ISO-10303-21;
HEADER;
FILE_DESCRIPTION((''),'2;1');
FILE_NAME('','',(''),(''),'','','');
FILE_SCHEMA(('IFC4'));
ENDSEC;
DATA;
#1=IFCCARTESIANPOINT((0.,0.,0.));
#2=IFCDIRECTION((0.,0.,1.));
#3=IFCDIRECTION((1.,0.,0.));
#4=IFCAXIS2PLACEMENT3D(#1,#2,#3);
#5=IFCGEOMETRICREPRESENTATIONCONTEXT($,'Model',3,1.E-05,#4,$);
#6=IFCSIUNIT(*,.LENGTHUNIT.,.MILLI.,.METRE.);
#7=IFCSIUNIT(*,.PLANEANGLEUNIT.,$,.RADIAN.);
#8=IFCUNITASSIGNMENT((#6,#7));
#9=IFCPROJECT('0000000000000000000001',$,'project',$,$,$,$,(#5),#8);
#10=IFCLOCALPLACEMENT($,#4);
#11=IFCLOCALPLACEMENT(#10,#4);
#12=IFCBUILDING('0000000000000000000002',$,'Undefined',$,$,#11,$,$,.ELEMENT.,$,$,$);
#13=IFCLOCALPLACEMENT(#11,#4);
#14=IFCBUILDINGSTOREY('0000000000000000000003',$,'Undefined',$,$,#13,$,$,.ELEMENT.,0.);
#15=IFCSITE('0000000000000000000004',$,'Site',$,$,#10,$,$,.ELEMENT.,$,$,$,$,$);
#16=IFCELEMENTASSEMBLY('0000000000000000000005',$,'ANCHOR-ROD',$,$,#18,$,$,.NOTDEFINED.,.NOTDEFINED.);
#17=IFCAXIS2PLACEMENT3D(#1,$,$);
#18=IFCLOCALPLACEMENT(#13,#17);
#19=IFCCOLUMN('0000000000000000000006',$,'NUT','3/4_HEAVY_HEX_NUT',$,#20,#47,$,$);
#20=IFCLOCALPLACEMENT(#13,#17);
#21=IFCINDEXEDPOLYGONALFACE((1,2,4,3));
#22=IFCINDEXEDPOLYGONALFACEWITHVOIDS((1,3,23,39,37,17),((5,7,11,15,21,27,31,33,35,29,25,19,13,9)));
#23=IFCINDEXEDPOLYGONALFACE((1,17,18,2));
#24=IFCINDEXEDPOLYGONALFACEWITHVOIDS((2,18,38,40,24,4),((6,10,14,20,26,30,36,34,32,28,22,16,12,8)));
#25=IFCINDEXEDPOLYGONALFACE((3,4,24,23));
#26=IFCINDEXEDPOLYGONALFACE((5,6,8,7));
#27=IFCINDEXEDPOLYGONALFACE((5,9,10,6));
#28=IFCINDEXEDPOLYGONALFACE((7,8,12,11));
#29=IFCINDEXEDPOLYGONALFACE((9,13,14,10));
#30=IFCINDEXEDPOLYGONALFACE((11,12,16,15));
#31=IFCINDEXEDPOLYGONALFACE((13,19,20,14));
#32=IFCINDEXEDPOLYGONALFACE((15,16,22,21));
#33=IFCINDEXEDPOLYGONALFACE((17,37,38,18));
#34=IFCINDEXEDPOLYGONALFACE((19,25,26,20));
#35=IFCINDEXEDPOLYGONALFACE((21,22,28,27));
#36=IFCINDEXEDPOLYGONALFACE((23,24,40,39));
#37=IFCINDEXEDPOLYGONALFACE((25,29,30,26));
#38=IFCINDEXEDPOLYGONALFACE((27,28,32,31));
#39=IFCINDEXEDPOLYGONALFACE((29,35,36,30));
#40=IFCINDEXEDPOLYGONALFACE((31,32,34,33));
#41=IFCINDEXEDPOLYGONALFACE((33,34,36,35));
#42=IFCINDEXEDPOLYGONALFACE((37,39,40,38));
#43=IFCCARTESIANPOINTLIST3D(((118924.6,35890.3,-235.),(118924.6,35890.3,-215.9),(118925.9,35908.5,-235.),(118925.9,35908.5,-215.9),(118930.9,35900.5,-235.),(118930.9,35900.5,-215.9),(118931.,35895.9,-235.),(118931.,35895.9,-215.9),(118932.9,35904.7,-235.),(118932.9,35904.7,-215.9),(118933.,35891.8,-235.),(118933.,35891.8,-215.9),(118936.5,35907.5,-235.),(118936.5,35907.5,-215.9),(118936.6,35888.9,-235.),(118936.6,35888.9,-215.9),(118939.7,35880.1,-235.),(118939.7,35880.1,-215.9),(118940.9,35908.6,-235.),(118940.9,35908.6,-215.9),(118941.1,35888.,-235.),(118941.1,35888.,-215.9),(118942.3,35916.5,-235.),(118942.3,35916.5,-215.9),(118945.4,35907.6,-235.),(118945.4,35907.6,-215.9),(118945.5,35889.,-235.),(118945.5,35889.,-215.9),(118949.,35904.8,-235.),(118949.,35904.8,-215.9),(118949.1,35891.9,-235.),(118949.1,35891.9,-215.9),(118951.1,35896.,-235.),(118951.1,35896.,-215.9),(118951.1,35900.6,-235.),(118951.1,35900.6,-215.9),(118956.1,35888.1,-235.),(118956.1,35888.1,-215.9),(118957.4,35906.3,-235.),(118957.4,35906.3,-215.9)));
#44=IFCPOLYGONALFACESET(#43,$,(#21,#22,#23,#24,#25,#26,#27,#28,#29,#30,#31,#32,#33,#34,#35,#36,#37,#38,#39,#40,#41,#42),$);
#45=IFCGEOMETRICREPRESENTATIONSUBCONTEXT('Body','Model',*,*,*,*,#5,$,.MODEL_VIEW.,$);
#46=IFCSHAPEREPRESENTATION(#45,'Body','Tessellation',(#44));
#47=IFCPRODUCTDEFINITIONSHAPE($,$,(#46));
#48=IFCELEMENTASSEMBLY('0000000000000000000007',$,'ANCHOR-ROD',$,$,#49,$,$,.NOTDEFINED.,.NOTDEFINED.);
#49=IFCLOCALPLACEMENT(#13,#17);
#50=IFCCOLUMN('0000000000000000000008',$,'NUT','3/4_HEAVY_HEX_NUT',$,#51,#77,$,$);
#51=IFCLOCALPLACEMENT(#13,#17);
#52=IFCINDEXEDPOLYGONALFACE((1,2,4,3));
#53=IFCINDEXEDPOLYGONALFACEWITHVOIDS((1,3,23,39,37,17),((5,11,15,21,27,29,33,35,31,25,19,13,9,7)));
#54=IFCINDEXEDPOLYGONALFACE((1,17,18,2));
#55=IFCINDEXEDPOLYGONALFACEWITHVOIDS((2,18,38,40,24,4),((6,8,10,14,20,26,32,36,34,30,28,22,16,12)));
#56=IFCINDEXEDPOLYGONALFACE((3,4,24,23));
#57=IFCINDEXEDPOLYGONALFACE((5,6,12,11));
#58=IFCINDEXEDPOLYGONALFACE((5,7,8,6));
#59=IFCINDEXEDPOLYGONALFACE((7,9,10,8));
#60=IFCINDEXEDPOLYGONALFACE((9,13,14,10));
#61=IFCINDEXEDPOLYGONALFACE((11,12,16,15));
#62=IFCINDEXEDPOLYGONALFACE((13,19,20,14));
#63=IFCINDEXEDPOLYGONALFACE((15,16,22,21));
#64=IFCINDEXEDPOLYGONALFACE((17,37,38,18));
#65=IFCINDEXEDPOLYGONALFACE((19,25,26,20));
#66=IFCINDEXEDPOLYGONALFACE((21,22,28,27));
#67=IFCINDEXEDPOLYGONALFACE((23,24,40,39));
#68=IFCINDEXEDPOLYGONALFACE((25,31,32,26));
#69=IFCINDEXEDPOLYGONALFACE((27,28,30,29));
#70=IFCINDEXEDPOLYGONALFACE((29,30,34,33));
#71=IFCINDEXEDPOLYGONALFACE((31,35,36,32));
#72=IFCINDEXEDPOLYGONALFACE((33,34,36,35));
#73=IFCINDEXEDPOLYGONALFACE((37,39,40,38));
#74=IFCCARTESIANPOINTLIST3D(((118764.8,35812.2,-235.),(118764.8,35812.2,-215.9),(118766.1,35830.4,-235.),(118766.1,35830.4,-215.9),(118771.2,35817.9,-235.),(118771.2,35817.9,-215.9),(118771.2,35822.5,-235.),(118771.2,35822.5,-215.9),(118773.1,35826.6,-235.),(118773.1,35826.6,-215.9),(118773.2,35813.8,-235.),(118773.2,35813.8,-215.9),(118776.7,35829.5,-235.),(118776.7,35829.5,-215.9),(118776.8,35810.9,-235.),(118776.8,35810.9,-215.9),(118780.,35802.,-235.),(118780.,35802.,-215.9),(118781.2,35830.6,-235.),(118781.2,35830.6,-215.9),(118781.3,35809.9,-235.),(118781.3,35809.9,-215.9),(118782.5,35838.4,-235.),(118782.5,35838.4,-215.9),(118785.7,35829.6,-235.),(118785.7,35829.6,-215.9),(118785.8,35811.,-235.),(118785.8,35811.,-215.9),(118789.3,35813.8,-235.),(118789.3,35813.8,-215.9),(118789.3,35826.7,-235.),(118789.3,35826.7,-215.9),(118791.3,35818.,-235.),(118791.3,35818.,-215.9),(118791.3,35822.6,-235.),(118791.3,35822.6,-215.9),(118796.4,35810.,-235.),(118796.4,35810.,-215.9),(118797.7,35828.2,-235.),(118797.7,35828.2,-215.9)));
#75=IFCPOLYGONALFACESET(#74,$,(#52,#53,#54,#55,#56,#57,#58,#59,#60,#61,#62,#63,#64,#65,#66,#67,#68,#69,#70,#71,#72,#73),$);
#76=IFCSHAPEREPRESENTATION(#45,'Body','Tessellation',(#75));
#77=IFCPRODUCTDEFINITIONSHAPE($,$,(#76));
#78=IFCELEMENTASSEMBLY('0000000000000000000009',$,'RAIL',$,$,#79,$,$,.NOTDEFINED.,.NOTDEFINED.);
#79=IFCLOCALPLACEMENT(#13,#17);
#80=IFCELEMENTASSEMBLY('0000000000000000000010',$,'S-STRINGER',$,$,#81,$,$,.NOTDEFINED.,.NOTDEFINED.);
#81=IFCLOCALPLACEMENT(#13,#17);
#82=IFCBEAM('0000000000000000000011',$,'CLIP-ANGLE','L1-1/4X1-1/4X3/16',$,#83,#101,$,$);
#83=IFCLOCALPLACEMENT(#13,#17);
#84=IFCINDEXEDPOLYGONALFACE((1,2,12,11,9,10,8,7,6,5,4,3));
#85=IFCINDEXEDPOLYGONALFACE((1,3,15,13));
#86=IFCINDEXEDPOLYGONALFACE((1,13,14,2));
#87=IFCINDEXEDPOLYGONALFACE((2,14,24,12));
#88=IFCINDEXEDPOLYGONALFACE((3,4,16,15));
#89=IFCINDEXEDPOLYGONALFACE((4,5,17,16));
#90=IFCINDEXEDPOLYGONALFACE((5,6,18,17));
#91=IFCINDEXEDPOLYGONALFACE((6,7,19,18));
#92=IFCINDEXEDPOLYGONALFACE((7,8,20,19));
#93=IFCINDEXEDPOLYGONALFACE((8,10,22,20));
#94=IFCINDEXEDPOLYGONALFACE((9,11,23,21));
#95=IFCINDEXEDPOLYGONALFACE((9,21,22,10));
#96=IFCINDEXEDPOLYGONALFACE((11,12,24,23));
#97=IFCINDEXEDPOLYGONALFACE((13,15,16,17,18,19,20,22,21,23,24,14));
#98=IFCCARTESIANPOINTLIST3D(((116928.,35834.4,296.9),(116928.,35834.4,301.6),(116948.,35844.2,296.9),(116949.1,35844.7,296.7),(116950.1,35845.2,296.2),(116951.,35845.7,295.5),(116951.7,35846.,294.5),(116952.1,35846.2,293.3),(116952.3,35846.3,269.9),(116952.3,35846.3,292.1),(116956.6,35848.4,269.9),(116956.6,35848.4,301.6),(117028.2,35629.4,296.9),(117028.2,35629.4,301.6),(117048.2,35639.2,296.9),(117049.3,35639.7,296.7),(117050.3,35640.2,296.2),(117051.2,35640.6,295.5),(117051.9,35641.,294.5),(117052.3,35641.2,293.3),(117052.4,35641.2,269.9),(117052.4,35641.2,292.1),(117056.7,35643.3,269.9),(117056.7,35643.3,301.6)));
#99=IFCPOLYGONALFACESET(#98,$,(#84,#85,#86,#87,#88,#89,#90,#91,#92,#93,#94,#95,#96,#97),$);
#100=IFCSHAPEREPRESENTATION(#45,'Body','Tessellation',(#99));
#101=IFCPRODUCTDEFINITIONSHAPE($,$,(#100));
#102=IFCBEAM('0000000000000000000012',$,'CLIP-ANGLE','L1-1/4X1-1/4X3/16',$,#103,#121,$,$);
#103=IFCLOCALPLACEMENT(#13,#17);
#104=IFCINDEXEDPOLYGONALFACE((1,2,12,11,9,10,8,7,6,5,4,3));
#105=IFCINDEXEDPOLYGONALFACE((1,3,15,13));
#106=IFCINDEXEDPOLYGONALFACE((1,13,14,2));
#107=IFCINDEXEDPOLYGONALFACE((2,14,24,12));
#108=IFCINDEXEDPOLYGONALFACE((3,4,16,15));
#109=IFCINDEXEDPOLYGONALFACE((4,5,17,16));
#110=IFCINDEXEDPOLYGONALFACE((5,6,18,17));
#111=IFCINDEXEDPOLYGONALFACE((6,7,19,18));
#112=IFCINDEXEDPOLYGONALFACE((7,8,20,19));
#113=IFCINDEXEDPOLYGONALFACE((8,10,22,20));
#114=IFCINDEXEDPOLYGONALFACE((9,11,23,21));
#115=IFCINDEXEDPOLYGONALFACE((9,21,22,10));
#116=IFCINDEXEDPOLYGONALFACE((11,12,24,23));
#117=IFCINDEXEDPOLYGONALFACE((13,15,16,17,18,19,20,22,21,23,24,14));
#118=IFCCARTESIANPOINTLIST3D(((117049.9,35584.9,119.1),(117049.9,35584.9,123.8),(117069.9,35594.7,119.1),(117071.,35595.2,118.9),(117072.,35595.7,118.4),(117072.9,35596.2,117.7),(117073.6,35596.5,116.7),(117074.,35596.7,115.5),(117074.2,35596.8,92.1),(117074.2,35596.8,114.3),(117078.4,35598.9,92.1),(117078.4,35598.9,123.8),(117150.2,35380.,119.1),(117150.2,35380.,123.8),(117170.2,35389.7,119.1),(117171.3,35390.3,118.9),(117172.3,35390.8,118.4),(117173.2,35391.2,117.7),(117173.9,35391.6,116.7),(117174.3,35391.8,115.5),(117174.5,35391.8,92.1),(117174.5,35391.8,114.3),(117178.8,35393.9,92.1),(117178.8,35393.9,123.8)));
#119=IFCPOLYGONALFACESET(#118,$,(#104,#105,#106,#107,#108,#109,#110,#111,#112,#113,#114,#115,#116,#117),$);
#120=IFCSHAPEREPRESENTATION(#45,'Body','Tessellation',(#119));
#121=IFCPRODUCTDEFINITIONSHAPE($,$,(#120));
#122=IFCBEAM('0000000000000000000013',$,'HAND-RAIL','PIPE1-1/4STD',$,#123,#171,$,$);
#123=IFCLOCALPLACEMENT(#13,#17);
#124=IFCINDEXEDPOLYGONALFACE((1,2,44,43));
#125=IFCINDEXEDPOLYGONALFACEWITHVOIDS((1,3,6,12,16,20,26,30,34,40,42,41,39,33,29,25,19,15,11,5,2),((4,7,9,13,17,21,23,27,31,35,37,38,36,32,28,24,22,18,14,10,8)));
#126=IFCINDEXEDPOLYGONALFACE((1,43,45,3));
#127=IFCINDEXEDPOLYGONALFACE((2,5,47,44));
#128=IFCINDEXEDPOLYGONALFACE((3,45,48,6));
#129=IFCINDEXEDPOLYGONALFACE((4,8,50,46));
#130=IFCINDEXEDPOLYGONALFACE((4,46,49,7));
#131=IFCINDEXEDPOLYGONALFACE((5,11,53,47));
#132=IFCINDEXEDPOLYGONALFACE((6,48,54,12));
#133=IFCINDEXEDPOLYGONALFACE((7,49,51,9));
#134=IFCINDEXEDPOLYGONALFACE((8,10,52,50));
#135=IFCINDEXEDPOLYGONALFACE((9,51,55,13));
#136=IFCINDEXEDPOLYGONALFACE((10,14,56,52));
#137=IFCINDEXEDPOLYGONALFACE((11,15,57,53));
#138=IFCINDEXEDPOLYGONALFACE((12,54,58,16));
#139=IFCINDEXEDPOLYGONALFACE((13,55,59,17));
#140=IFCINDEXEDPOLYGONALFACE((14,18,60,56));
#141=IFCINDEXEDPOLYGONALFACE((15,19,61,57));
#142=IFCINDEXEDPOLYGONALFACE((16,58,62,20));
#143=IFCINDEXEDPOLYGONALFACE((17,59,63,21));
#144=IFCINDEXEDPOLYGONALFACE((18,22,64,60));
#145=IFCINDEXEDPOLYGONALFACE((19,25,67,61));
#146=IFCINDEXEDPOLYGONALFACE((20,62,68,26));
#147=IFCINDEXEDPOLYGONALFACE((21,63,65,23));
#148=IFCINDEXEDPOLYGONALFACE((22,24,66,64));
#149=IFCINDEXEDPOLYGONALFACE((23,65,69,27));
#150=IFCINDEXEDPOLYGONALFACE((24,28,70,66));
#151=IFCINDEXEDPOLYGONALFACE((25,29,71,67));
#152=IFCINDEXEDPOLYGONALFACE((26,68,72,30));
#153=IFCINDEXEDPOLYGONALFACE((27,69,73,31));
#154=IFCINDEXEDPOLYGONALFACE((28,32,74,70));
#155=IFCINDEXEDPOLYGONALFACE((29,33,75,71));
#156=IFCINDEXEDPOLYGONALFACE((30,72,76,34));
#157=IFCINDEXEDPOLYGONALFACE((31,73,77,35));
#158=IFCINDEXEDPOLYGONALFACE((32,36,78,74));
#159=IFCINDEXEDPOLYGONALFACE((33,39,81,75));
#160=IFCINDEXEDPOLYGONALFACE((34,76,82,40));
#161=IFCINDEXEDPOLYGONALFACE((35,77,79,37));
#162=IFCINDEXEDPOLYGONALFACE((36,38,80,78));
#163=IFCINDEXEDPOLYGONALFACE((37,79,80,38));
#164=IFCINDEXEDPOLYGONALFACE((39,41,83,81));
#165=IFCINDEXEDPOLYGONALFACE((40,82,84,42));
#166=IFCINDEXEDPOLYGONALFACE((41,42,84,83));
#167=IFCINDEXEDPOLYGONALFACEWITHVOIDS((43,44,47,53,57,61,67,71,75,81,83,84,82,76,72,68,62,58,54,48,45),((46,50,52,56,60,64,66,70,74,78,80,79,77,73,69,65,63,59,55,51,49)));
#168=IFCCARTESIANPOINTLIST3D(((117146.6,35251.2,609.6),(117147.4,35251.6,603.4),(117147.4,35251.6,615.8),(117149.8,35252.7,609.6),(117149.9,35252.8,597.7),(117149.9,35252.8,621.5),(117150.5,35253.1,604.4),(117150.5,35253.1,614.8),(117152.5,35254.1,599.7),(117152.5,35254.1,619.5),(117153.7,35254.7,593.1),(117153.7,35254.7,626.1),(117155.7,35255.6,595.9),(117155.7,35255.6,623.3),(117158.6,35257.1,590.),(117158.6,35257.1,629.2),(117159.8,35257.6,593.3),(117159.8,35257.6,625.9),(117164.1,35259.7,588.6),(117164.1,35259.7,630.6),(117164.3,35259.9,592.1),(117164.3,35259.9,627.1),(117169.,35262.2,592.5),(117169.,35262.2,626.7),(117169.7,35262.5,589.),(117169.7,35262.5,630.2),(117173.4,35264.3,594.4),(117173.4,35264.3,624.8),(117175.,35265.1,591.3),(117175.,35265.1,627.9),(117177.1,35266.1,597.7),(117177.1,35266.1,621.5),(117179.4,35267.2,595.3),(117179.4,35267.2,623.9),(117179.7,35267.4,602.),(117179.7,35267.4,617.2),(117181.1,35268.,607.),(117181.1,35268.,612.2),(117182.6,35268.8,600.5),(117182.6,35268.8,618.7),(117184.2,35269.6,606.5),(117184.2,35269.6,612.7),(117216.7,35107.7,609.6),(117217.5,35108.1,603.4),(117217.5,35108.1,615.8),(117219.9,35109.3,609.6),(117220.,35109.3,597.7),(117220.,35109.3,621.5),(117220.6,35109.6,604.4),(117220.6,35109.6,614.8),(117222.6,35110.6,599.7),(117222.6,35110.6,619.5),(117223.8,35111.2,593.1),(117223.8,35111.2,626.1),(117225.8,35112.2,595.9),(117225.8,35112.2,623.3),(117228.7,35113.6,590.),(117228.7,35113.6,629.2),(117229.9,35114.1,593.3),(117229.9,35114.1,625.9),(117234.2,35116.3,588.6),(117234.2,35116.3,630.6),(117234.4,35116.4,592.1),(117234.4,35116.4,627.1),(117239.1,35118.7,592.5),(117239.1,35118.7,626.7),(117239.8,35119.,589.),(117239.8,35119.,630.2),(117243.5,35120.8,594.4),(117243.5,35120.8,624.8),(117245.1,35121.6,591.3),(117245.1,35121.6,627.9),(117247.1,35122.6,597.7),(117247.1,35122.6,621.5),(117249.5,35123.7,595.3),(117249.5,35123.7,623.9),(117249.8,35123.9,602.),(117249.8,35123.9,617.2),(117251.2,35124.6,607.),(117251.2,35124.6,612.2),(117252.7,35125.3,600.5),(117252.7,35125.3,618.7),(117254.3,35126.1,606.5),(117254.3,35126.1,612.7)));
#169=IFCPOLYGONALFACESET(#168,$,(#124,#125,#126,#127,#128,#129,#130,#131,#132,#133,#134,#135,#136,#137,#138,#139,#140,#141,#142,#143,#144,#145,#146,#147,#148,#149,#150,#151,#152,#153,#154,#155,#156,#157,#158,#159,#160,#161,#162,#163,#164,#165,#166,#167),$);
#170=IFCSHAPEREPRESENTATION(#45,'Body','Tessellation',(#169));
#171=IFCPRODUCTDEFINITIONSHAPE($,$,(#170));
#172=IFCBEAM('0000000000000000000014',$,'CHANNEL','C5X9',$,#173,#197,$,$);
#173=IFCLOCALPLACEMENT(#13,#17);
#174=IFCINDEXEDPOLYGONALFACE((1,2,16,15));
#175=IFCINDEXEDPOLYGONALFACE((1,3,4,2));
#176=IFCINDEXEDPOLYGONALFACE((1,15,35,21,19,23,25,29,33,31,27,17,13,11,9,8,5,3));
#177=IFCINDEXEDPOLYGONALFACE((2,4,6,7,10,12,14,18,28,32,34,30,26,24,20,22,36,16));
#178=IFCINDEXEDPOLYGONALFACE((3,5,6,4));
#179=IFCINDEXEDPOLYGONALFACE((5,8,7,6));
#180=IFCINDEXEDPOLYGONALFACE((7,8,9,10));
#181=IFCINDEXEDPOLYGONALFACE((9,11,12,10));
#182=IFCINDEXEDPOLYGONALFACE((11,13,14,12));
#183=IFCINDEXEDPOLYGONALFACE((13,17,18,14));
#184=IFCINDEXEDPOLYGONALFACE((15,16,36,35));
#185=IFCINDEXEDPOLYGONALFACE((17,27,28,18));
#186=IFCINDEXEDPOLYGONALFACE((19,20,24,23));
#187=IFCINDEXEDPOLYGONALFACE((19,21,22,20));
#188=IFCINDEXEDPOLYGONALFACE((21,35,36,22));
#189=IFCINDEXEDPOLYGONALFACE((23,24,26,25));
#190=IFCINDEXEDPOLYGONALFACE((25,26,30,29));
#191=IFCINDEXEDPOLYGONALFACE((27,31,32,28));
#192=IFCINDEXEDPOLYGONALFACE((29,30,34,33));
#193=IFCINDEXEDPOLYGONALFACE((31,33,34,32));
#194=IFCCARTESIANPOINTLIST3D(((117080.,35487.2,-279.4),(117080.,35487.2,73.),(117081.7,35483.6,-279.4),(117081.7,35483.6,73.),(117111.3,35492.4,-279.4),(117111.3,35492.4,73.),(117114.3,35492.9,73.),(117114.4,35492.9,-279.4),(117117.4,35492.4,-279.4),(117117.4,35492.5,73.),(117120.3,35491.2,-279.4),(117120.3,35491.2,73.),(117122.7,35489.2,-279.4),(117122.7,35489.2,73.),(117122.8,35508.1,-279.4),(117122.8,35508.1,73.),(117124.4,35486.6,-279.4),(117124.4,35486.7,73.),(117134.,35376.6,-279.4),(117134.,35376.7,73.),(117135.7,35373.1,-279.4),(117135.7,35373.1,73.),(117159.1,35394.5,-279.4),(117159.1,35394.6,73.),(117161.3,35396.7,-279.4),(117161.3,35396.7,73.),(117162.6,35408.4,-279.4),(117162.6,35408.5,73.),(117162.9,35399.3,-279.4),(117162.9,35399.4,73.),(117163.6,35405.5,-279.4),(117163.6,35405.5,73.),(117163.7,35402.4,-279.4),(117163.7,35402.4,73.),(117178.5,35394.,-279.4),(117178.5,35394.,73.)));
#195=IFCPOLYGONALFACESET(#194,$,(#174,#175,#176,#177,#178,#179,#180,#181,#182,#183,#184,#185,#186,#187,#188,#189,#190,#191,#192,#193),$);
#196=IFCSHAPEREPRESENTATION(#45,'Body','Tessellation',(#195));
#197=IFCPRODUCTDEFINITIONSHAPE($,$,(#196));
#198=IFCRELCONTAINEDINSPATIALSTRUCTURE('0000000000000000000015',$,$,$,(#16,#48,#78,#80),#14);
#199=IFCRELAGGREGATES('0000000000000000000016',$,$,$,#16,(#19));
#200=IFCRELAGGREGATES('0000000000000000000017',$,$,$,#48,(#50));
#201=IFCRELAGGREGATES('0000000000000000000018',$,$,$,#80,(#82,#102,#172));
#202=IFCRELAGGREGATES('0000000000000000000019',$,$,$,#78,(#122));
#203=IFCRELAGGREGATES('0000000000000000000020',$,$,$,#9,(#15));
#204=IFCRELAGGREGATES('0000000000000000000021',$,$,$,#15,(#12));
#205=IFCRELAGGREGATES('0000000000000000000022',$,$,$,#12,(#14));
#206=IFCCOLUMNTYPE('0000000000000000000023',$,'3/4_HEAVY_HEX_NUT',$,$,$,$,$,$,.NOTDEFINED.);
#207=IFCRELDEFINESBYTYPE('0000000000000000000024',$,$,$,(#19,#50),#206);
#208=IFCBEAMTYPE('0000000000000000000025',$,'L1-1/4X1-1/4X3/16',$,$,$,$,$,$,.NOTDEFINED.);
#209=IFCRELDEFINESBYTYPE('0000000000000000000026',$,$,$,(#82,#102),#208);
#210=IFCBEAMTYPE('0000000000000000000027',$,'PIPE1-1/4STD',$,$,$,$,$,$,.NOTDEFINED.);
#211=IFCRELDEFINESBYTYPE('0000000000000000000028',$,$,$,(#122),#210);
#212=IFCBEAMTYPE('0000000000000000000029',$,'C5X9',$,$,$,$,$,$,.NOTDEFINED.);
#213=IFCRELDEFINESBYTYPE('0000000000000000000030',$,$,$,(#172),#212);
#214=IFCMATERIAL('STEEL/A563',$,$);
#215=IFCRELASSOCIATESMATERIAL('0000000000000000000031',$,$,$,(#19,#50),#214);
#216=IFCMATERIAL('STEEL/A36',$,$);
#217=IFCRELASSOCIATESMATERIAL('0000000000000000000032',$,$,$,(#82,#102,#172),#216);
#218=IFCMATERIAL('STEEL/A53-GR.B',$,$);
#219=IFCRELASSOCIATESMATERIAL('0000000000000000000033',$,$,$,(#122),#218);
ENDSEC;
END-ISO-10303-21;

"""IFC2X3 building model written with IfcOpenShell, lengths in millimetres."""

from ifc_helpers import new_model, si_unit, frame, origin_with_axes, origin_2d_with_axis, place, context, subcontext, project, spatial, polyline, hollow_circle, l_section, u_section, outline, extrude, material, type_object, element, aggregate, save


model = new_model("IFC2X3")

# Units and contexts
model_context = context("Model", 3, precision=1e-05, world=origin_with_axes())
body_context = subcontext(model_context, "Body", "Model", "MODEL_VIEW")
ifc_project = project(units=[si_unit("LENGTHUNIT", "METRE", prefix="MILLI"), si_unit("PLANEANGLEUNIT", "RADIAN")], contexts=[model_context])

# Site, building, storey
site_placement = place(None, origin_with_axes())
site = spatial("IfcSite", under=ifc_project, at=site_placement, Name="Site", CompositionType="ELEMENT")
building_placement = place(site_placement, origin_with_axes())
building = spatial("IfcBuilding", under=site, at=building_placement, Name="Undefined", CompositionType="ELEMENT")
storey_placement = place(building_placement, origin_with_axes())
storey = spatial("IfcBuildingStorey", under=building, at=storey_placement, Name="Undefined", CompositionType="ELEMENT", Elevation=0.0)

# Element assemblies, columns
ifc_material_1 = material(Name="STEEL/A563")
column_type_1 = type_object("IfcColumnType", Name="3/4_HEAVY_HEX_NUT", PredefinedType="NOTDEFINED")
assembly_1_placement = place(storey_placement, origin_with_axes())
assembly_1 = element("IfcElementAssembly", 1, at=assembly_1_placement, inside=storey, Name="ANCHOR-ROD", AssemblyPlace="NOTDEFINED", PredefinedType="NOTDEFINED")
column_1_placement = place(assembly_1_placement, frame((118941.0, 35898.3, -215.9), z_axis=(0.0, 0.0, -1.0), x_axis=(-0.438909, 0.898531, 0.0)))
column_1 = element("IfcColumn", 2, at=column_1_placement, type_object=column_type_1, material=ifc_material_1, Name="NUT", Description="3/4_HEAVY_HEX_NUT", context=body_context, shape_type="SweptSolid", body=[
    extrude(outline(polyline([(-9.1, 15.8), (9.1, 15.8), (18.3, 0.0), (9.1, -15.8), (-9.1, -15.8), (-18.3, 0.0), (-9.1, 15.8)]), holes=[polyline([(8.1, -6.4), (10.1, -2.3), (10.1, 2.3), (8.1, 6.4), (4.5, 9.3), (0.0, 10.3), (-4.5, 9.3), (-8.1, 6.4), (-10.1, 2.3), (-10.1, -2.3), (-8.1, -6.4), (-4.5, -9.3), (0.0, -10.3), (4.5, -9.3), (8.1, -6.4)])]), frame((0.0, 0.0, 19.1), z_axis=(0.0, 0.0, -1.0), x_axis=(0.0, 1.0, 0.0)), (0.0, 0.0, 1.0), 19.1),
])
aggregate(assembly_1, [column_1])
assembly_2_placement = place(storey_placement, origin_with_axes())
assembly_2 = element("IfcElementAssembly", 3, at=assembly_2_placement, inside=storey, Name="ANCHOR-ROD", AssemblyPlace="NOTDEFINED", PredefinedType="NOTDEFINED")
column_2_placement = place(assembly_2_placement, frame((118781.2, 35820.2, -215.9), z_axis=(0.0, 0.0, -1.0), x_axis=(0.438909, -0.898531, 0.0)))
column_2 = element("IfcColumn", 4, at=column_2_placement, type_object=column_type_1, material=ifc_material_1, Name="NUT", Description="3/4_HEAVY_HEX_NUT", context=body_context, shape_type="SweptSolid", body=[
    extrude(outline(polyline([(-9.1, 15.8), (9.1, 15.8), (18.3, 0.0), (9.1, -15.8), (-9.1, -15.8), (-18.3, 0.0), (-9.1, 15.8)]), holes=[polyline([(8.1, -6.4), (10.1, -2.3), (10.1, 2.3), (8.1, 6.4), (4.5, 9.3), (0.0, 10.3), (-4.5, 9.3), (-8.1, 6.4), (-10.1, 2.3), (-10.1, -2.3), (-8.1, -6.4), (-4.5, -9.3), (0.0, -10.3), (4.5, -9.3), (8.1, -6.4)])]), frame((0.0, 0.0, 19.1), z_axis=(0.0, 0.0, -1.0), x_axis=(0.0, 1.0, 0.0)), (0.0, 0.0, 1.0), 19.1),
])
aggregate(assembly_2, [column_2])
assembly_3_placement = place(storey_placement, origin_with_axes())
assembly_3 = element("IfcElementAssembly", 5, at=assembly_3_placement, inside=storey, Name="RAIL", AssemblyPlace="NOTDEFINED", PredefinedType="NOTDEFINED")

# Element assembly, beams
assembly_4_placement = place(storey_placement, origin_with_axes())
assembly_4 = element("IfcElementAssembly", 6, at=assembly_4_placement, inside=storey, Name="S-STRINGER", AssemblyPlace="NOTDEFINED", PredefinedType="NOTDEFINED")
ifc_material_2 = material(Name="STEEL/A36")
beam_type_1 = type_object("IfcBeamType", Name="L1-1/4X1-1/4X3/16", PredefinedType="NOTDEFINED")
beam_1_placement = place(assembly_4_placement, frame((116942.3, 35841.4, 285.7), z_axis=(-0.898531, -0.43891, 0.0), x_axis=(0.438909, -0.898531, 0.0)))
beam_1 = element("IfcBeam", 7, at=beam_1_placement, type_object=beam_type_1, material=ifc_material_2, Name="CLIP-ANGLE", Description="L1-1/4X1-1/4X3/16", context=body_context, shape_type="SweptSolid", body=[
    extrude(l_section(Depth=31.8, Width=31.8, Thickness=4.8, FilletRadius=4.8, at=origin_2d_with_axis()), frame((228.2, 0.0, 0.0), z_axis=(-1.0, 0.0, 0.0), x_axis=(0.0, -1.0, 0.0)), (0.0, 0.0, 1.0), 228.2),
])
beam_2_placement = place(assembly_4_placement, frame((117064.2, 35591.9, 107.9), z_axis=(-0.898171, -0.439646, 0.0), x_axis=(0.439646, -0.898171, 0.0)))
beam_2 = element("IfcBeam", 8, at=beam_2_placement, type_object=beam_type_1, material=ifc_material_2, Name="CLIP-ANGLE", Description="L1-1/4X1-1/4X3/16", context=body_context, shape_type="SweptSolid", body=[
    extrude(l_section(Depth=31.8, Width=31.8, Thickness=4.8, FilletRadius=4.8, at=origin_2d_with_axis()), frame((228.2, 0.0, 0.0), z_axis=(-1.0, 0.0, 0.0), x_axis=(0.0, -1.0, 0.0)), (0.0, 0.0, 1.0), 228.2),
])

# Beams
ifc_material_3 = material(Name="STEEL/A53-GR.B")
beam_type_2 = type_object("IfcBeamType", Name="PIPE1-1/4STD", PredefinedType="NOTDEFINED")
beam_3_placement = place(assembly_3_placement, frame((117235.6, 35117.0, 609.6), z_axis=(0.0, 0.0, -1.0), x_axis=(-0.438909, 0.898531, 0.0)))
beam_3 = element("IfcBeam", 9, at=beam_3_placement, type_object=beam_type_2, material=ifc_material_3, Name="HAND-RAIL", Description="PIPE1-1/4STD", context=body_context, shape_type="SweptSolid", body=[
    extrude(hollow_circle(Radius=21.1, WallThickness=3.6, at=origin_2d_with_axis()), frame((159.7, 0.0, 0.0), z_axis=(-1.0, 0.0, 0.0), x_axis=(0.0, -1.0, 0.0)), (0.0, 0.0, 1.0), 159.7),
])
beam_type_3 = type_object("IfcBeamType", Name="C5X9", PredefinedType="NOTDEFINED")
beam_4_placement = place(assembly_4_placement, frame((117129.2, 35440.6, 73.0), z_axis=(0.438909, -0.898531, 0.000129), x_axis=(0.000057, -0.000116, -1.0)))
beam_4 = element("IfcBeam", 10, at=beam_4_placement, type_object=beam_type_3, material=ifc_material_2, Name="CHANNEL", Description="C5X9", context=body_context, shape_type="SweptSolid", body=[
    extrude(u_section(Depth=127.0, FlangeWidth=47.6, WebThickness=7.9, FlangeThickness=7.9, FilletRadius=11.1, FlangeSlope=0.165084, at=origin_2d_with_axis()), frame((352.4, 0.0, 0.0), z_axis=(-1.0, 0.0, 0.0), x_axis=(0.0, -1.0, 0.0)), (0.0, 0.0, 1.0), 352.4),
])

aggregate(assembly_4, [beam_1, beam_2, beam_4])

aggregate(assembly_3, [beam_3])

save(model, "model.ifc")
